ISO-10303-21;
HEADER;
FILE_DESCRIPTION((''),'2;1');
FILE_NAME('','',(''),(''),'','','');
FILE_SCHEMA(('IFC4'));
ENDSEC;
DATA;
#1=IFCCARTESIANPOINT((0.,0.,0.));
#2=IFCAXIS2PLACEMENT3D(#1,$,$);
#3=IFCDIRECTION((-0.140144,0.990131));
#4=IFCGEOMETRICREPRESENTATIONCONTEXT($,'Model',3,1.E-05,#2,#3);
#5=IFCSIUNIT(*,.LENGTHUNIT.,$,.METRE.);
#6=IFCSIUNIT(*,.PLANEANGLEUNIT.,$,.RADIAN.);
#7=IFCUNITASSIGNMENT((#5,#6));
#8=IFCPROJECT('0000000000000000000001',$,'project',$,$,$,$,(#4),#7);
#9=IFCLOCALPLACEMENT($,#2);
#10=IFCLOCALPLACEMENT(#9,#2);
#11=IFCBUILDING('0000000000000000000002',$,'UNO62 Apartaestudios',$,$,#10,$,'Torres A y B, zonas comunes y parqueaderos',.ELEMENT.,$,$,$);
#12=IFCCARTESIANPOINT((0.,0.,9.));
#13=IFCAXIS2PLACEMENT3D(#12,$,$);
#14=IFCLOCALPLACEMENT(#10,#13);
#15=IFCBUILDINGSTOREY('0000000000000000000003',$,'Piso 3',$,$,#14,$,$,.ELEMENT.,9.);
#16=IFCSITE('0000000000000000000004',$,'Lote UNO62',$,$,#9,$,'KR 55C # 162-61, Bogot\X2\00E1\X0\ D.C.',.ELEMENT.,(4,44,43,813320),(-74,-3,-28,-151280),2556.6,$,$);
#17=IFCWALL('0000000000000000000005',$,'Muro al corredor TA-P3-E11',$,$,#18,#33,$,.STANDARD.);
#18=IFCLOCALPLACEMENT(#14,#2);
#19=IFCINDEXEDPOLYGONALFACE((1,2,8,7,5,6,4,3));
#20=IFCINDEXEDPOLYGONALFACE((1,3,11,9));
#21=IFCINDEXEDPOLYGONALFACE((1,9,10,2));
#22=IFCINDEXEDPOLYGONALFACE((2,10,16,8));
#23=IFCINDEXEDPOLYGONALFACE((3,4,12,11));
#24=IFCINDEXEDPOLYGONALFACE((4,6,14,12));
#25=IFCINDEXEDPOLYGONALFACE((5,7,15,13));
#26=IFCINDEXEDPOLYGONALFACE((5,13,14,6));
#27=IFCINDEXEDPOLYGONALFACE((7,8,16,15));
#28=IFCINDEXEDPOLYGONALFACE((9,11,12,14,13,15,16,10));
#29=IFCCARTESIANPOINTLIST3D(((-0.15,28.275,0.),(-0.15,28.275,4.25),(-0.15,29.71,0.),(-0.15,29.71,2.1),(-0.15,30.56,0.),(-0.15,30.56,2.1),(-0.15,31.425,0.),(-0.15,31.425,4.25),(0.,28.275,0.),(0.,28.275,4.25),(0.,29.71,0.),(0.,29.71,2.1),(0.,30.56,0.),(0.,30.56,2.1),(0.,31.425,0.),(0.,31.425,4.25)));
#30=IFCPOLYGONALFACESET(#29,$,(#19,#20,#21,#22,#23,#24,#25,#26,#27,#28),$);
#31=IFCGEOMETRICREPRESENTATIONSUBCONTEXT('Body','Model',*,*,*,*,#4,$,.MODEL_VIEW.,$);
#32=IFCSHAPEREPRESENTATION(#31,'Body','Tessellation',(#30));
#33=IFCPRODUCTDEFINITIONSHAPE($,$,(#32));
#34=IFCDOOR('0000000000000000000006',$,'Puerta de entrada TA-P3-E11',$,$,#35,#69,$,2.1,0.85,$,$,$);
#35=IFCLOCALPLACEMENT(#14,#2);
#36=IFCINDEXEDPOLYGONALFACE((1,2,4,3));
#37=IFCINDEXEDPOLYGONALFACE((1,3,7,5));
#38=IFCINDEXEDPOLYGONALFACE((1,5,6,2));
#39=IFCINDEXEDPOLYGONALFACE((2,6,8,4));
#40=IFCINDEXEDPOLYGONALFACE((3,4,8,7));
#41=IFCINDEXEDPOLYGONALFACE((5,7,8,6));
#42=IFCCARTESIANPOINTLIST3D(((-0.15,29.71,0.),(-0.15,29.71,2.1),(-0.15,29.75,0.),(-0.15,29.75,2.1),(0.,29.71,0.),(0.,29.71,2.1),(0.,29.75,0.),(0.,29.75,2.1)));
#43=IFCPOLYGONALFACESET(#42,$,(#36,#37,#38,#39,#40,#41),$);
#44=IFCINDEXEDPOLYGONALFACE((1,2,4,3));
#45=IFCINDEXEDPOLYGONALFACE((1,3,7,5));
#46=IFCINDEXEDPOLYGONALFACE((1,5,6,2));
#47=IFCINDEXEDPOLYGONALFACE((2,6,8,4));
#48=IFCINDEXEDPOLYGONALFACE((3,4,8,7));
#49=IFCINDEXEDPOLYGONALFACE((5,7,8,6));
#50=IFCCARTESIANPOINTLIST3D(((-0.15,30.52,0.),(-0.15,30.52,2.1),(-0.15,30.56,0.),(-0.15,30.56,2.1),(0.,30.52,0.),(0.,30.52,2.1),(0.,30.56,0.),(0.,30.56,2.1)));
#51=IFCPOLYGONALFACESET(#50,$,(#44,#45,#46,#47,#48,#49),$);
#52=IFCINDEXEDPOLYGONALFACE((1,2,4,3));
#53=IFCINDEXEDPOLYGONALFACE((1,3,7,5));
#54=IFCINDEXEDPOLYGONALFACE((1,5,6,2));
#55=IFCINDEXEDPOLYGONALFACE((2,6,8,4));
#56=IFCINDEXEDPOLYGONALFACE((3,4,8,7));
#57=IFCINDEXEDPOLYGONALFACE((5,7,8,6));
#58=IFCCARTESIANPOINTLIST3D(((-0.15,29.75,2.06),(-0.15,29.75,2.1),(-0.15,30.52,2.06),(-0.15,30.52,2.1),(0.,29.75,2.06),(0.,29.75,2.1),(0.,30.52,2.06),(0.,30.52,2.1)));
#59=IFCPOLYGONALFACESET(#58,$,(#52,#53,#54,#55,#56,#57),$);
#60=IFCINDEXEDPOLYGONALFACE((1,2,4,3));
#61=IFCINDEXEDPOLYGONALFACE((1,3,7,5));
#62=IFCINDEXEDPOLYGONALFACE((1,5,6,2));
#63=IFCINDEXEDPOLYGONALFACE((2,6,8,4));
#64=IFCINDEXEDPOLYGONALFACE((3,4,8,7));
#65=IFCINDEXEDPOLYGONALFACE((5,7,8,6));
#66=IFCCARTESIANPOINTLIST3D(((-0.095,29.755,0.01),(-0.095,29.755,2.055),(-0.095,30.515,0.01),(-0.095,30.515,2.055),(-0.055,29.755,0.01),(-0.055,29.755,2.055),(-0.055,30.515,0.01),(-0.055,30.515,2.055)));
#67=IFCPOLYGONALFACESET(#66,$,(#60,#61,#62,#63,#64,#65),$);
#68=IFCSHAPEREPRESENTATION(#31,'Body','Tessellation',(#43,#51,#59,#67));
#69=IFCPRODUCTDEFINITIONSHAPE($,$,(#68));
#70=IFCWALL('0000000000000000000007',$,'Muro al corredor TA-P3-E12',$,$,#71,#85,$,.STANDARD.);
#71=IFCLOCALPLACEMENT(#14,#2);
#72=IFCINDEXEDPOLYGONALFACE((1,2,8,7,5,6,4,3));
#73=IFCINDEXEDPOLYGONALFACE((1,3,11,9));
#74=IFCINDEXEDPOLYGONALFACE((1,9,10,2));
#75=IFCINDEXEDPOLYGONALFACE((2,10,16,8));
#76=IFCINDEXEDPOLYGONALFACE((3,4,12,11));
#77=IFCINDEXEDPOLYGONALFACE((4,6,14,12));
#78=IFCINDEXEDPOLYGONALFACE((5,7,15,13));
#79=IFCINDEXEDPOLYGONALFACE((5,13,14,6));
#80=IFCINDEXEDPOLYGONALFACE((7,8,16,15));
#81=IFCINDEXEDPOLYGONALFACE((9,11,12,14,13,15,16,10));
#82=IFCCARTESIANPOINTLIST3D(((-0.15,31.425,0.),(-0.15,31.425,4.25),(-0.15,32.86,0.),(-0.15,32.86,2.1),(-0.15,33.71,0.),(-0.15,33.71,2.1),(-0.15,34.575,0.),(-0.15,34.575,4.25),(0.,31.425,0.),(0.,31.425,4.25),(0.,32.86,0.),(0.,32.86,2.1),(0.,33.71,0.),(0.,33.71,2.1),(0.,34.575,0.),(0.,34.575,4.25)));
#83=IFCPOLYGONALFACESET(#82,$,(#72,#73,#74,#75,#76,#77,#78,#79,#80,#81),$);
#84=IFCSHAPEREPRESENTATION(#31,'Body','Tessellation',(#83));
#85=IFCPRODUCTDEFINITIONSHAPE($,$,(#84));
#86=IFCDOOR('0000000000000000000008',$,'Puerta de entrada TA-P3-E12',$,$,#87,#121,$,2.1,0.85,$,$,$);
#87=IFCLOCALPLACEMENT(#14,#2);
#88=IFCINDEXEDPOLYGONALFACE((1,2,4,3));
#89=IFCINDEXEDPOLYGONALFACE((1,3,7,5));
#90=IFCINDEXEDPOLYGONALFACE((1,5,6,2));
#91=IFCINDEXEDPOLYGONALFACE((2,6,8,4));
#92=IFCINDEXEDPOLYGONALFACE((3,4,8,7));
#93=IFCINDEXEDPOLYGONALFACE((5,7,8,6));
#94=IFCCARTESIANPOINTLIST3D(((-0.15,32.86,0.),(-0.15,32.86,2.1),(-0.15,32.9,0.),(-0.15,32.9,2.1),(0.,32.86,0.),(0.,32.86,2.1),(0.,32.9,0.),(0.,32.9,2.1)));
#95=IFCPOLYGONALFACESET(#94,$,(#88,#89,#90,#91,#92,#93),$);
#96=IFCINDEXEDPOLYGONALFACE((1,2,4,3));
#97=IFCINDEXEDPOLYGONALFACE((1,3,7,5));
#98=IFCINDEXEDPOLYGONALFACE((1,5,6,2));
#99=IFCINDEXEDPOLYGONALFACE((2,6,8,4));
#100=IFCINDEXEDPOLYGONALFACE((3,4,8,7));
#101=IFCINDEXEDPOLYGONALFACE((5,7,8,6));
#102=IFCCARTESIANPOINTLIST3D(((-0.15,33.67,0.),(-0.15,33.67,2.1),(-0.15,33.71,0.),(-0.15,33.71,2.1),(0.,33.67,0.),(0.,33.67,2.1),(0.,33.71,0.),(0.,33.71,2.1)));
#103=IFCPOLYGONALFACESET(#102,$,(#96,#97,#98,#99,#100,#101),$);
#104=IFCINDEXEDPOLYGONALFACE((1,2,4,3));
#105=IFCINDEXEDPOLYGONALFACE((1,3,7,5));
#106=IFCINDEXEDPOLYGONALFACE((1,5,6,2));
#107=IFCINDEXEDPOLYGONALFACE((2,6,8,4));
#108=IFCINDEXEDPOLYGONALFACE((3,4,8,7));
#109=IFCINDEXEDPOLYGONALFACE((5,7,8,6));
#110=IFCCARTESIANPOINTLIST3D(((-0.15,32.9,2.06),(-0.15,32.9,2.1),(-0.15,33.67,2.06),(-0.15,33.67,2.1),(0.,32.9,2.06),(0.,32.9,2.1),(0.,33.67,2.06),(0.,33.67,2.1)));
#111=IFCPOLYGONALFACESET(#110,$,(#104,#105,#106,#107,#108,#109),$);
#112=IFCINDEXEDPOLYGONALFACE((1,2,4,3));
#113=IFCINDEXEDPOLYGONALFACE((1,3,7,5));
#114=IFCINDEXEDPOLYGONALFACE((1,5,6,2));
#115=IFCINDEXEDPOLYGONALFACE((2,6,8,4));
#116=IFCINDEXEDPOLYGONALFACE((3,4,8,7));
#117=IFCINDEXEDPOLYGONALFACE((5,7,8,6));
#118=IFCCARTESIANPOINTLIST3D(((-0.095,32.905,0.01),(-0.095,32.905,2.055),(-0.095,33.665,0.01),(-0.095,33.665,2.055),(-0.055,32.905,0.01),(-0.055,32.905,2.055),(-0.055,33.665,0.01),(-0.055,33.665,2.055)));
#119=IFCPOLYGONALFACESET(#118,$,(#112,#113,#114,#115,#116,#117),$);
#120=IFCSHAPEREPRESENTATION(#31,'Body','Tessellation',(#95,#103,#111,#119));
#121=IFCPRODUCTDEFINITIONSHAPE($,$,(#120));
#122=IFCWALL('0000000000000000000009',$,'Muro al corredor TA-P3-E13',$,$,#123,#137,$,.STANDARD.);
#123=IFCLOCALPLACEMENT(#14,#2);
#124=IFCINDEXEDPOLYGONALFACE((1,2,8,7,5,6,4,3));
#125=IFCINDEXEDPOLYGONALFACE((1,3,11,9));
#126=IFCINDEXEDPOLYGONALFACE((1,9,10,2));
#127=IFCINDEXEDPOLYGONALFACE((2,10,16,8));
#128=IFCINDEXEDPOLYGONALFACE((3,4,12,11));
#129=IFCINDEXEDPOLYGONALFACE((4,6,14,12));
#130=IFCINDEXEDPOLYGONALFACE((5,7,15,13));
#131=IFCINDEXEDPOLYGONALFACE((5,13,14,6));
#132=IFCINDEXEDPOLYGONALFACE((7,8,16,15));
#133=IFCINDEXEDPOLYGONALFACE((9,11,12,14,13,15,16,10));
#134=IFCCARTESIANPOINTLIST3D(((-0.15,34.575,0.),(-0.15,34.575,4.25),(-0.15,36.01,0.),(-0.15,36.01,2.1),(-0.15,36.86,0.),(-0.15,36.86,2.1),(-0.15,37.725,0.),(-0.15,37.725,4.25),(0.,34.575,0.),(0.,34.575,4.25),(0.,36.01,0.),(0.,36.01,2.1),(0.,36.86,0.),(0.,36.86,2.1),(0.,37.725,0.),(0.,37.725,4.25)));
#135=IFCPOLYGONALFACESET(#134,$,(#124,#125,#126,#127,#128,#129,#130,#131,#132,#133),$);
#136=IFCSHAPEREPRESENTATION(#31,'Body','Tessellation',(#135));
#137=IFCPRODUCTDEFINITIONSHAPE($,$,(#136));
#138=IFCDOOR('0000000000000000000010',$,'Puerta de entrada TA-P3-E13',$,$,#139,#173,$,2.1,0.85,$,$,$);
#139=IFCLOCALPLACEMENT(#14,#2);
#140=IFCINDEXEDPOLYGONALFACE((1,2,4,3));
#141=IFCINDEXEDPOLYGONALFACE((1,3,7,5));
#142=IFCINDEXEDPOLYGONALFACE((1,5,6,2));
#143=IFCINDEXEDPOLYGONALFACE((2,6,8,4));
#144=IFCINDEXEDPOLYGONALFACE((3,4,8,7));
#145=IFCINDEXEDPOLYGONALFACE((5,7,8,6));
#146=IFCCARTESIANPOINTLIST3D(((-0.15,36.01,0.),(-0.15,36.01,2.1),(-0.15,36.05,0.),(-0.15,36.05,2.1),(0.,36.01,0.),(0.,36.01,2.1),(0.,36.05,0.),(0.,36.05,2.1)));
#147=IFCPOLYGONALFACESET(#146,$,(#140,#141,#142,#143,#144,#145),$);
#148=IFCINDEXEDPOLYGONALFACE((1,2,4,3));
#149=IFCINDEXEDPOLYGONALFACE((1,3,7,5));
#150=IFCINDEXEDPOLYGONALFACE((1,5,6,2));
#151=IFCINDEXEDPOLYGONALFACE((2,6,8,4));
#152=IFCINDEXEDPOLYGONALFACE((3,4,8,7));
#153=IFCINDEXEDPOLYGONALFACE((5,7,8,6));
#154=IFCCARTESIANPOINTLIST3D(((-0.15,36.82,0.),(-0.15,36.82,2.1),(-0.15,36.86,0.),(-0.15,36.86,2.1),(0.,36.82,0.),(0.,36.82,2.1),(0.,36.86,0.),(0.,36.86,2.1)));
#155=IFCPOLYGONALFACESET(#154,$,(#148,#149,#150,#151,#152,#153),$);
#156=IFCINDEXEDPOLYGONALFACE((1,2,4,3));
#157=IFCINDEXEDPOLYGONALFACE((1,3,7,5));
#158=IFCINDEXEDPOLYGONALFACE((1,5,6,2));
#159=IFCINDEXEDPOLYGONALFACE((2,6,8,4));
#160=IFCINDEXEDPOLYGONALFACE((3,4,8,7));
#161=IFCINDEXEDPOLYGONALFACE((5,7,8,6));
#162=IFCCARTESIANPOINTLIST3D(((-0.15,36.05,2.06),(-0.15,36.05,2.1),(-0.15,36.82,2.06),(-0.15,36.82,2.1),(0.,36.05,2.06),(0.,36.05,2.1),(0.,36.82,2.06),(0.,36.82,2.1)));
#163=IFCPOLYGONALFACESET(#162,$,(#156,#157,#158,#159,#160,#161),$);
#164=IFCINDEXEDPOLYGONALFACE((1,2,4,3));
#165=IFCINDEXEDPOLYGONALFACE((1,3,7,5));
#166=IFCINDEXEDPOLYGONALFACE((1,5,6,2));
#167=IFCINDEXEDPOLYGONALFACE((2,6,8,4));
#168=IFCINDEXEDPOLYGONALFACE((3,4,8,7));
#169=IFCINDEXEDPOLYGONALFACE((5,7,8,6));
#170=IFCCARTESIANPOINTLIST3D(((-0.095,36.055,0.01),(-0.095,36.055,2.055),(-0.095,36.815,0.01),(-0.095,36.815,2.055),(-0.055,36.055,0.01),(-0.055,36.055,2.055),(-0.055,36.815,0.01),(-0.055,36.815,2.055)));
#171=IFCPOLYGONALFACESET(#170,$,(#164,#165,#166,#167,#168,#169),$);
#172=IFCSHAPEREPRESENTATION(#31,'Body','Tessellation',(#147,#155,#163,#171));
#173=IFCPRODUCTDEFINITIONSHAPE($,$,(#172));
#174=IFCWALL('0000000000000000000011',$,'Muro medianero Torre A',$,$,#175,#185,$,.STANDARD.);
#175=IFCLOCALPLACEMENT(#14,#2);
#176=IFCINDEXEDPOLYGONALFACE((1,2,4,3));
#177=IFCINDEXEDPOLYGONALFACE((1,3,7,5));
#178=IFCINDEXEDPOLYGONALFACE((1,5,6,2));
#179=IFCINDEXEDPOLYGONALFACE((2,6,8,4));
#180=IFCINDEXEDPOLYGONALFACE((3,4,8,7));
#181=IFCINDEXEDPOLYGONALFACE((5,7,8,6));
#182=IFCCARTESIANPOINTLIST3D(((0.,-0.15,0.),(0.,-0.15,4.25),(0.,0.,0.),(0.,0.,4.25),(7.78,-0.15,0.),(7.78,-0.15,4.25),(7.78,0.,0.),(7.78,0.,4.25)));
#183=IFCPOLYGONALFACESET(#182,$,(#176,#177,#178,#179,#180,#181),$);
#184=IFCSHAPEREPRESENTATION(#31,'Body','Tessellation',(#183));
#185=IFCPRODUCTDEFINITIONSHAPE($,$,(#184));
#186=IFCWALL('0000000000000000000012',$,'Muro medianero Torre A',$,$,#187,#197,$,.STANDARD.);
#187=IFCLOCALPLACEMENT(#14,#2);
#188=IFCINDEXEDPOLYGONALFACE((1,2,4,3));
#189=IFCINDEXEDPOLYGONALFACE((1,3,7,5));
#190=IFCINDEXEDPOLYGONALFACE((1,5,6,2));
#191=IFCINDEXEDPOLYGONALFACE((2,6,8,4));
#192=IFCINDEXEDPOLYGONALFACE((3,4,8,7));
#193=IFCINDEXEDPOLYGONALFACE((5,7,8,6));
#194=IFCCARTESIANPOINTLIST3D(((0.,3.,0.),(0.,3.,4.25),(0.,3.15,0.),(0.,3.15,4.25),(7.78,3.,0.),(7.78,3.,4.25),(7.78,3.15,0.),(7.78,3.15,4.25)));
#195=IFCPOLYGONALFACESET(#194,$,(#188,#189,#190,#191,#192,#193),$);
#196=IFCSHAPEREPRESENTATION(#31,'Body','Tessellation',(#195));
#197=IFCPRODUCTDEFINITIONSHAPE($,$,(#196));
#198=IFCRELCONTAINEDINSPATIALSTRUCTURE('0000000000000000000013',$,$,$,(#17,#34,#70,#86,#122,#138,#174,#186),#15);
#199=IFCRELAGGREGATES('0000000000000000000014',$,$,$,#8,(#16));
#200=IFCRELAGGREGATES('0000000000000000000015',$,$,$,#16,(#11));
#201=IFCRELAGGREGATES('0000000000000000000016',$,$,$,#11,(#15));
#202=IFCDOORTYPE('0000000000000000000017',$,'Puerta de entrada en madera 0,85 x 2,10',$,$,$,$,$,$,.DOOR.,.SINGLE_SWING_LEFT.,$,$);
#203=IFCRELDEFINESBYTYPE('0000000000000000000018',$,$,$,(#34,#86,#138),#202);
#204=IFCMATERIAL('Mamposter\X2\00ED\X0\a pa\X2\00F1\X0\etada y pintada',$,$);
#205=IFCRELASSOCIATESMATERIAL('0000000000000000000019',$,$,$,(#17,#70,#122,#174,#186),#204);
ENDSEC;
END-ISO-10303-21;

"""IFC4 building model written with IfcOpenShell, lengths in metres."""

from ifc_helpers import new_model, si_unit, direction, frame, frame_2d, origin, place, context, subcontext, project, spatial, rectangle, extrude, source, transform, mapped, material, type_object, type_shapes, element, fill, save


model = new_model("IFC4")

# Units and contexts
model_context = context("Model", 3, precision=1e-05, world=origin(), true_north=direction((-0.140144, 0.990131)))
body_context = subcontext(model_context, "Body", "Model", "MODEL_VIEW")
ifc_project = project(units=[si_unit("LENGTHUNIT", "METRE"), si_unit("PLANEANGLEUNIT", "RADIAN")], contexts=[model_context])

# Site, building, storey
site_placement = place(None, origin())
site = spatial("IfcSite", under=ifc_project, at=site_placement, Name="Lote UNO62", LongName="KR 55C # 162-61, Bogotá D.C.", CompositionType="ELEMENT", RefLatitude=(4, 44, 43, 813320), RefLongitude=(-74, -3, -28, -151280), RefElevation=2556.6)
building_placement = place(site_placement, origin())
building = spatial("IfcBuilding", under=site, at=building_placement, Name="UNO62 Apartaestudios", LongName="Torres A y B, zonas comunes y parqueaderos", CompositionType="ELEMENT")
storey_placement = place(building_placement, frame((0.0, 0.0, 9.0)))
storey = spatial("IfcBuildingStorey", under=building, at=storey_placement, Name="Piso 3", CompositionType="ELEMENT", Elevation=9.0)

# Walls, openings, doors
ifc_material = material(Name="Mampostería pañetada y pintada")
door_type = type_object("IfcDoorType", Name="Puerta de entrada en madera 0,85 x 2,10", OperationType="SINGLE_SWING_LEFT", PredefinedType="DOOR")
shared_shape = source(origin(), body_context, "Body", "SweptSolid", [
    extrude(rectangle(XDim=0.15, YDim=0.04, at=frame_2d((-0.075, 1.38))), origin(), (0.0, 0.0, 1.0), 2.1),
    extrude(rectangle(XDim=0.15, YDim=0.04, at=frame_2d((-0.075, 2.19))), origin(), (0.0, 0.0, 1.0), 2.1),
    extrude(rectangle(XDim=0.15, YDim=0.77, at=frame_2d((-0.075, 1.785))), frame((0.0, 0.0, 2.06)), (0.0, 0.0, 1.0), 0.04),
    extrude(rectangle(XDim=0.04, YDim=0.76, at=frame_2d((-0.075, 1.785))), frame((0.0, 0.0, 0.01)), (0.0, 0.0, 1.0), 2.045),
])
type_shapes(door_type, [shared_shape])
wall_1_placement = place(storey_placement, origin())
wall_1 = element("IfcWall", 1, at=wall_1_placement, inside=storey, material=ifc_material, Name="Muro al corredor TA-P3-E11", PredefinedType="STANDARD", context=body_context, shape_type="SweptSolid", body=[
    extrude(rectangle(XDim=0.15, YDim=3.15, at=frame_2d((-0.075, 29.85))), origin(), (0.0, 0.0, 1.0), 4.25),
])
opening_1_placement = place(wall_1_placement, origin())
opening_1 = element("IfcOpeningElement", 2, at=opening_1_placement, cuts=wall_1, PredefinedType="OPENING", context=body_context, shape_type="SweptSolid", body=[
    extrude(rectangle(XDim=0.25, YDim=0.85, at=frame_2d((-0.075, 30.135))), origin(), (0.0, 0.0, 1.0), 2.1),
])
placement_1 = place(storey_placement, frame((0.0, 28.35, 0.0)))
door_1_placement = place(placement_1, origin())
door_1 = element("IfcDoor", 3, at=door_1_placement, inside=storey, type_object=door_type, Name="Puerta de entrada TA-P3-E11", OverallHeight=2.1, OverallWidth=0.85, context=body_context, shape_type="MappedRepresentation", body=[
    mapped(shared_shape, transform((0.0, 0.0, 0.0))),
])
fill(opening_1, door_1)
wall_2_placement = place(storey_placement, origin())
wall_2 = element("IfcWall", 4, at=wall_2_placement, inside=storey, material=ifc_material, Name="Muro al corredor TA-P3-E12", PredefinedType="STANDARD", context=body_context, shape_type="SweptSolid", body=[
    extrude(rectangle(XDim=0.15, YDim=3.15, at=frame_2d((-0.075, 33.0))), origin(), (0.0, 0.0, 1.0), 4.25),
])
opening_2_placement = place(wall_2_placement, origin())
opening_2 = element("IfcOpeningElement", 5, at=opening_2_placement, cuts=wall_2, PredefinedType="OPENING", context=body_context, shape_type="SweptSolid", body=[
    extrude(rectangle(XDim=0.25, YDim=0.85, at=frame_2d((-0.075, 33.285))), origin(), (0.0, 0.0, 1.0), 2.1),
])
placement_2 = place(storey_placement, frame((0.0, 31.5, 0.0)))
door_2_placement = place(placement_2, origin())
door_2 = element("IfcDoor", 6, at=door_2_placement, inside=storey, type_object=door_type, Name="Puerta de entrada TA-P3-E12", OverallHeight=2.1, OverallWidth=0.85, context=body_context, shape_type="MappedRepresentation", body=[
    mapped(shared_shape, transform((0.0, 0.0, 0.0))),
])
fill(opening_2, door_2)
wall_3_placement = place(storey_placement, origin())
wall_3 = element("IfcWall", 7, at=wall_3_placement, inside=storey, material=ifc_material, Name="Muro al corredor TA-P3-E13", PredefinedType="STANDARD", context=body_context, shape_type="SweptSolid", body=[
    extrude(rectangle(XDim=0.15, YDim=3.15, at=frame_2d((-0.075, 36.15))), origin(), (0.0, 0.0, 1.0), 4.25),
])
opening_3_placement = place(wall_3_placement, origin())
opening_3 = element("IfcOpeningElement", 8, at=opening_3_placement, cuts=wall_3, PredefinedType="OPENING", context=body_context, shape_type="SweptSolid", body=[
    extrude(rectangle(XDim=0.25, YDim=0.85, at=frame_2d((-0.075, 36.435))), origin(), (0.0, 0.0, 1.0), 2.1),
])
placement_3 = place(storey_placement, frame((0.0, 34.65, 0.0)))
door_3_placement = place(placement_3, origin())
door_3 = element("IfcDoor", 9, at=door_3_placement, inside=storey, type_object=door_type, Name="Puerta de entrada TA-P3-E13", OverallHeight=2.1, OverallWidth=0.85, context=body_context, shape_type="MappedRepresentation", body=[
    mapped(shared_shape, transform((0.0, 0.0, 0.0))),
])
fill(opening_3, door_3)

# Walls
wall_4_placement = place(storey_placement, origin())
element("IfcWall", 10, at=wall_4_placement, inside=storey, material=ifc_material, Name="Muro medianero Torre A", PredefinedType="STANDARD", context=body_context, shape_type="SweptSolid", body=[
    extrude(rectangle(XDim=7.78, YDim=0.15, at=frame_2d((3.89, -0.075))), origin(), (0.0, 0.0, 1.0), 4.25),
])
wall_5_placement = place(storey_placement, origin())
element("IfcWall", 11, at=wall_5_placement, inside=storey, material=ifc_material, Name="Muro medianero Torre A", PredefinedType="STANDARD", context=body_context, shape_type="SweptSolid", body=[
    extrude(rectangle(XDim=7.78, YDim=0.15, at=frame_2d((3.89, 3.075))), origin(), (0.0, 0.0, 1.0), 4.25),
])

save(model, "model.ifc")
